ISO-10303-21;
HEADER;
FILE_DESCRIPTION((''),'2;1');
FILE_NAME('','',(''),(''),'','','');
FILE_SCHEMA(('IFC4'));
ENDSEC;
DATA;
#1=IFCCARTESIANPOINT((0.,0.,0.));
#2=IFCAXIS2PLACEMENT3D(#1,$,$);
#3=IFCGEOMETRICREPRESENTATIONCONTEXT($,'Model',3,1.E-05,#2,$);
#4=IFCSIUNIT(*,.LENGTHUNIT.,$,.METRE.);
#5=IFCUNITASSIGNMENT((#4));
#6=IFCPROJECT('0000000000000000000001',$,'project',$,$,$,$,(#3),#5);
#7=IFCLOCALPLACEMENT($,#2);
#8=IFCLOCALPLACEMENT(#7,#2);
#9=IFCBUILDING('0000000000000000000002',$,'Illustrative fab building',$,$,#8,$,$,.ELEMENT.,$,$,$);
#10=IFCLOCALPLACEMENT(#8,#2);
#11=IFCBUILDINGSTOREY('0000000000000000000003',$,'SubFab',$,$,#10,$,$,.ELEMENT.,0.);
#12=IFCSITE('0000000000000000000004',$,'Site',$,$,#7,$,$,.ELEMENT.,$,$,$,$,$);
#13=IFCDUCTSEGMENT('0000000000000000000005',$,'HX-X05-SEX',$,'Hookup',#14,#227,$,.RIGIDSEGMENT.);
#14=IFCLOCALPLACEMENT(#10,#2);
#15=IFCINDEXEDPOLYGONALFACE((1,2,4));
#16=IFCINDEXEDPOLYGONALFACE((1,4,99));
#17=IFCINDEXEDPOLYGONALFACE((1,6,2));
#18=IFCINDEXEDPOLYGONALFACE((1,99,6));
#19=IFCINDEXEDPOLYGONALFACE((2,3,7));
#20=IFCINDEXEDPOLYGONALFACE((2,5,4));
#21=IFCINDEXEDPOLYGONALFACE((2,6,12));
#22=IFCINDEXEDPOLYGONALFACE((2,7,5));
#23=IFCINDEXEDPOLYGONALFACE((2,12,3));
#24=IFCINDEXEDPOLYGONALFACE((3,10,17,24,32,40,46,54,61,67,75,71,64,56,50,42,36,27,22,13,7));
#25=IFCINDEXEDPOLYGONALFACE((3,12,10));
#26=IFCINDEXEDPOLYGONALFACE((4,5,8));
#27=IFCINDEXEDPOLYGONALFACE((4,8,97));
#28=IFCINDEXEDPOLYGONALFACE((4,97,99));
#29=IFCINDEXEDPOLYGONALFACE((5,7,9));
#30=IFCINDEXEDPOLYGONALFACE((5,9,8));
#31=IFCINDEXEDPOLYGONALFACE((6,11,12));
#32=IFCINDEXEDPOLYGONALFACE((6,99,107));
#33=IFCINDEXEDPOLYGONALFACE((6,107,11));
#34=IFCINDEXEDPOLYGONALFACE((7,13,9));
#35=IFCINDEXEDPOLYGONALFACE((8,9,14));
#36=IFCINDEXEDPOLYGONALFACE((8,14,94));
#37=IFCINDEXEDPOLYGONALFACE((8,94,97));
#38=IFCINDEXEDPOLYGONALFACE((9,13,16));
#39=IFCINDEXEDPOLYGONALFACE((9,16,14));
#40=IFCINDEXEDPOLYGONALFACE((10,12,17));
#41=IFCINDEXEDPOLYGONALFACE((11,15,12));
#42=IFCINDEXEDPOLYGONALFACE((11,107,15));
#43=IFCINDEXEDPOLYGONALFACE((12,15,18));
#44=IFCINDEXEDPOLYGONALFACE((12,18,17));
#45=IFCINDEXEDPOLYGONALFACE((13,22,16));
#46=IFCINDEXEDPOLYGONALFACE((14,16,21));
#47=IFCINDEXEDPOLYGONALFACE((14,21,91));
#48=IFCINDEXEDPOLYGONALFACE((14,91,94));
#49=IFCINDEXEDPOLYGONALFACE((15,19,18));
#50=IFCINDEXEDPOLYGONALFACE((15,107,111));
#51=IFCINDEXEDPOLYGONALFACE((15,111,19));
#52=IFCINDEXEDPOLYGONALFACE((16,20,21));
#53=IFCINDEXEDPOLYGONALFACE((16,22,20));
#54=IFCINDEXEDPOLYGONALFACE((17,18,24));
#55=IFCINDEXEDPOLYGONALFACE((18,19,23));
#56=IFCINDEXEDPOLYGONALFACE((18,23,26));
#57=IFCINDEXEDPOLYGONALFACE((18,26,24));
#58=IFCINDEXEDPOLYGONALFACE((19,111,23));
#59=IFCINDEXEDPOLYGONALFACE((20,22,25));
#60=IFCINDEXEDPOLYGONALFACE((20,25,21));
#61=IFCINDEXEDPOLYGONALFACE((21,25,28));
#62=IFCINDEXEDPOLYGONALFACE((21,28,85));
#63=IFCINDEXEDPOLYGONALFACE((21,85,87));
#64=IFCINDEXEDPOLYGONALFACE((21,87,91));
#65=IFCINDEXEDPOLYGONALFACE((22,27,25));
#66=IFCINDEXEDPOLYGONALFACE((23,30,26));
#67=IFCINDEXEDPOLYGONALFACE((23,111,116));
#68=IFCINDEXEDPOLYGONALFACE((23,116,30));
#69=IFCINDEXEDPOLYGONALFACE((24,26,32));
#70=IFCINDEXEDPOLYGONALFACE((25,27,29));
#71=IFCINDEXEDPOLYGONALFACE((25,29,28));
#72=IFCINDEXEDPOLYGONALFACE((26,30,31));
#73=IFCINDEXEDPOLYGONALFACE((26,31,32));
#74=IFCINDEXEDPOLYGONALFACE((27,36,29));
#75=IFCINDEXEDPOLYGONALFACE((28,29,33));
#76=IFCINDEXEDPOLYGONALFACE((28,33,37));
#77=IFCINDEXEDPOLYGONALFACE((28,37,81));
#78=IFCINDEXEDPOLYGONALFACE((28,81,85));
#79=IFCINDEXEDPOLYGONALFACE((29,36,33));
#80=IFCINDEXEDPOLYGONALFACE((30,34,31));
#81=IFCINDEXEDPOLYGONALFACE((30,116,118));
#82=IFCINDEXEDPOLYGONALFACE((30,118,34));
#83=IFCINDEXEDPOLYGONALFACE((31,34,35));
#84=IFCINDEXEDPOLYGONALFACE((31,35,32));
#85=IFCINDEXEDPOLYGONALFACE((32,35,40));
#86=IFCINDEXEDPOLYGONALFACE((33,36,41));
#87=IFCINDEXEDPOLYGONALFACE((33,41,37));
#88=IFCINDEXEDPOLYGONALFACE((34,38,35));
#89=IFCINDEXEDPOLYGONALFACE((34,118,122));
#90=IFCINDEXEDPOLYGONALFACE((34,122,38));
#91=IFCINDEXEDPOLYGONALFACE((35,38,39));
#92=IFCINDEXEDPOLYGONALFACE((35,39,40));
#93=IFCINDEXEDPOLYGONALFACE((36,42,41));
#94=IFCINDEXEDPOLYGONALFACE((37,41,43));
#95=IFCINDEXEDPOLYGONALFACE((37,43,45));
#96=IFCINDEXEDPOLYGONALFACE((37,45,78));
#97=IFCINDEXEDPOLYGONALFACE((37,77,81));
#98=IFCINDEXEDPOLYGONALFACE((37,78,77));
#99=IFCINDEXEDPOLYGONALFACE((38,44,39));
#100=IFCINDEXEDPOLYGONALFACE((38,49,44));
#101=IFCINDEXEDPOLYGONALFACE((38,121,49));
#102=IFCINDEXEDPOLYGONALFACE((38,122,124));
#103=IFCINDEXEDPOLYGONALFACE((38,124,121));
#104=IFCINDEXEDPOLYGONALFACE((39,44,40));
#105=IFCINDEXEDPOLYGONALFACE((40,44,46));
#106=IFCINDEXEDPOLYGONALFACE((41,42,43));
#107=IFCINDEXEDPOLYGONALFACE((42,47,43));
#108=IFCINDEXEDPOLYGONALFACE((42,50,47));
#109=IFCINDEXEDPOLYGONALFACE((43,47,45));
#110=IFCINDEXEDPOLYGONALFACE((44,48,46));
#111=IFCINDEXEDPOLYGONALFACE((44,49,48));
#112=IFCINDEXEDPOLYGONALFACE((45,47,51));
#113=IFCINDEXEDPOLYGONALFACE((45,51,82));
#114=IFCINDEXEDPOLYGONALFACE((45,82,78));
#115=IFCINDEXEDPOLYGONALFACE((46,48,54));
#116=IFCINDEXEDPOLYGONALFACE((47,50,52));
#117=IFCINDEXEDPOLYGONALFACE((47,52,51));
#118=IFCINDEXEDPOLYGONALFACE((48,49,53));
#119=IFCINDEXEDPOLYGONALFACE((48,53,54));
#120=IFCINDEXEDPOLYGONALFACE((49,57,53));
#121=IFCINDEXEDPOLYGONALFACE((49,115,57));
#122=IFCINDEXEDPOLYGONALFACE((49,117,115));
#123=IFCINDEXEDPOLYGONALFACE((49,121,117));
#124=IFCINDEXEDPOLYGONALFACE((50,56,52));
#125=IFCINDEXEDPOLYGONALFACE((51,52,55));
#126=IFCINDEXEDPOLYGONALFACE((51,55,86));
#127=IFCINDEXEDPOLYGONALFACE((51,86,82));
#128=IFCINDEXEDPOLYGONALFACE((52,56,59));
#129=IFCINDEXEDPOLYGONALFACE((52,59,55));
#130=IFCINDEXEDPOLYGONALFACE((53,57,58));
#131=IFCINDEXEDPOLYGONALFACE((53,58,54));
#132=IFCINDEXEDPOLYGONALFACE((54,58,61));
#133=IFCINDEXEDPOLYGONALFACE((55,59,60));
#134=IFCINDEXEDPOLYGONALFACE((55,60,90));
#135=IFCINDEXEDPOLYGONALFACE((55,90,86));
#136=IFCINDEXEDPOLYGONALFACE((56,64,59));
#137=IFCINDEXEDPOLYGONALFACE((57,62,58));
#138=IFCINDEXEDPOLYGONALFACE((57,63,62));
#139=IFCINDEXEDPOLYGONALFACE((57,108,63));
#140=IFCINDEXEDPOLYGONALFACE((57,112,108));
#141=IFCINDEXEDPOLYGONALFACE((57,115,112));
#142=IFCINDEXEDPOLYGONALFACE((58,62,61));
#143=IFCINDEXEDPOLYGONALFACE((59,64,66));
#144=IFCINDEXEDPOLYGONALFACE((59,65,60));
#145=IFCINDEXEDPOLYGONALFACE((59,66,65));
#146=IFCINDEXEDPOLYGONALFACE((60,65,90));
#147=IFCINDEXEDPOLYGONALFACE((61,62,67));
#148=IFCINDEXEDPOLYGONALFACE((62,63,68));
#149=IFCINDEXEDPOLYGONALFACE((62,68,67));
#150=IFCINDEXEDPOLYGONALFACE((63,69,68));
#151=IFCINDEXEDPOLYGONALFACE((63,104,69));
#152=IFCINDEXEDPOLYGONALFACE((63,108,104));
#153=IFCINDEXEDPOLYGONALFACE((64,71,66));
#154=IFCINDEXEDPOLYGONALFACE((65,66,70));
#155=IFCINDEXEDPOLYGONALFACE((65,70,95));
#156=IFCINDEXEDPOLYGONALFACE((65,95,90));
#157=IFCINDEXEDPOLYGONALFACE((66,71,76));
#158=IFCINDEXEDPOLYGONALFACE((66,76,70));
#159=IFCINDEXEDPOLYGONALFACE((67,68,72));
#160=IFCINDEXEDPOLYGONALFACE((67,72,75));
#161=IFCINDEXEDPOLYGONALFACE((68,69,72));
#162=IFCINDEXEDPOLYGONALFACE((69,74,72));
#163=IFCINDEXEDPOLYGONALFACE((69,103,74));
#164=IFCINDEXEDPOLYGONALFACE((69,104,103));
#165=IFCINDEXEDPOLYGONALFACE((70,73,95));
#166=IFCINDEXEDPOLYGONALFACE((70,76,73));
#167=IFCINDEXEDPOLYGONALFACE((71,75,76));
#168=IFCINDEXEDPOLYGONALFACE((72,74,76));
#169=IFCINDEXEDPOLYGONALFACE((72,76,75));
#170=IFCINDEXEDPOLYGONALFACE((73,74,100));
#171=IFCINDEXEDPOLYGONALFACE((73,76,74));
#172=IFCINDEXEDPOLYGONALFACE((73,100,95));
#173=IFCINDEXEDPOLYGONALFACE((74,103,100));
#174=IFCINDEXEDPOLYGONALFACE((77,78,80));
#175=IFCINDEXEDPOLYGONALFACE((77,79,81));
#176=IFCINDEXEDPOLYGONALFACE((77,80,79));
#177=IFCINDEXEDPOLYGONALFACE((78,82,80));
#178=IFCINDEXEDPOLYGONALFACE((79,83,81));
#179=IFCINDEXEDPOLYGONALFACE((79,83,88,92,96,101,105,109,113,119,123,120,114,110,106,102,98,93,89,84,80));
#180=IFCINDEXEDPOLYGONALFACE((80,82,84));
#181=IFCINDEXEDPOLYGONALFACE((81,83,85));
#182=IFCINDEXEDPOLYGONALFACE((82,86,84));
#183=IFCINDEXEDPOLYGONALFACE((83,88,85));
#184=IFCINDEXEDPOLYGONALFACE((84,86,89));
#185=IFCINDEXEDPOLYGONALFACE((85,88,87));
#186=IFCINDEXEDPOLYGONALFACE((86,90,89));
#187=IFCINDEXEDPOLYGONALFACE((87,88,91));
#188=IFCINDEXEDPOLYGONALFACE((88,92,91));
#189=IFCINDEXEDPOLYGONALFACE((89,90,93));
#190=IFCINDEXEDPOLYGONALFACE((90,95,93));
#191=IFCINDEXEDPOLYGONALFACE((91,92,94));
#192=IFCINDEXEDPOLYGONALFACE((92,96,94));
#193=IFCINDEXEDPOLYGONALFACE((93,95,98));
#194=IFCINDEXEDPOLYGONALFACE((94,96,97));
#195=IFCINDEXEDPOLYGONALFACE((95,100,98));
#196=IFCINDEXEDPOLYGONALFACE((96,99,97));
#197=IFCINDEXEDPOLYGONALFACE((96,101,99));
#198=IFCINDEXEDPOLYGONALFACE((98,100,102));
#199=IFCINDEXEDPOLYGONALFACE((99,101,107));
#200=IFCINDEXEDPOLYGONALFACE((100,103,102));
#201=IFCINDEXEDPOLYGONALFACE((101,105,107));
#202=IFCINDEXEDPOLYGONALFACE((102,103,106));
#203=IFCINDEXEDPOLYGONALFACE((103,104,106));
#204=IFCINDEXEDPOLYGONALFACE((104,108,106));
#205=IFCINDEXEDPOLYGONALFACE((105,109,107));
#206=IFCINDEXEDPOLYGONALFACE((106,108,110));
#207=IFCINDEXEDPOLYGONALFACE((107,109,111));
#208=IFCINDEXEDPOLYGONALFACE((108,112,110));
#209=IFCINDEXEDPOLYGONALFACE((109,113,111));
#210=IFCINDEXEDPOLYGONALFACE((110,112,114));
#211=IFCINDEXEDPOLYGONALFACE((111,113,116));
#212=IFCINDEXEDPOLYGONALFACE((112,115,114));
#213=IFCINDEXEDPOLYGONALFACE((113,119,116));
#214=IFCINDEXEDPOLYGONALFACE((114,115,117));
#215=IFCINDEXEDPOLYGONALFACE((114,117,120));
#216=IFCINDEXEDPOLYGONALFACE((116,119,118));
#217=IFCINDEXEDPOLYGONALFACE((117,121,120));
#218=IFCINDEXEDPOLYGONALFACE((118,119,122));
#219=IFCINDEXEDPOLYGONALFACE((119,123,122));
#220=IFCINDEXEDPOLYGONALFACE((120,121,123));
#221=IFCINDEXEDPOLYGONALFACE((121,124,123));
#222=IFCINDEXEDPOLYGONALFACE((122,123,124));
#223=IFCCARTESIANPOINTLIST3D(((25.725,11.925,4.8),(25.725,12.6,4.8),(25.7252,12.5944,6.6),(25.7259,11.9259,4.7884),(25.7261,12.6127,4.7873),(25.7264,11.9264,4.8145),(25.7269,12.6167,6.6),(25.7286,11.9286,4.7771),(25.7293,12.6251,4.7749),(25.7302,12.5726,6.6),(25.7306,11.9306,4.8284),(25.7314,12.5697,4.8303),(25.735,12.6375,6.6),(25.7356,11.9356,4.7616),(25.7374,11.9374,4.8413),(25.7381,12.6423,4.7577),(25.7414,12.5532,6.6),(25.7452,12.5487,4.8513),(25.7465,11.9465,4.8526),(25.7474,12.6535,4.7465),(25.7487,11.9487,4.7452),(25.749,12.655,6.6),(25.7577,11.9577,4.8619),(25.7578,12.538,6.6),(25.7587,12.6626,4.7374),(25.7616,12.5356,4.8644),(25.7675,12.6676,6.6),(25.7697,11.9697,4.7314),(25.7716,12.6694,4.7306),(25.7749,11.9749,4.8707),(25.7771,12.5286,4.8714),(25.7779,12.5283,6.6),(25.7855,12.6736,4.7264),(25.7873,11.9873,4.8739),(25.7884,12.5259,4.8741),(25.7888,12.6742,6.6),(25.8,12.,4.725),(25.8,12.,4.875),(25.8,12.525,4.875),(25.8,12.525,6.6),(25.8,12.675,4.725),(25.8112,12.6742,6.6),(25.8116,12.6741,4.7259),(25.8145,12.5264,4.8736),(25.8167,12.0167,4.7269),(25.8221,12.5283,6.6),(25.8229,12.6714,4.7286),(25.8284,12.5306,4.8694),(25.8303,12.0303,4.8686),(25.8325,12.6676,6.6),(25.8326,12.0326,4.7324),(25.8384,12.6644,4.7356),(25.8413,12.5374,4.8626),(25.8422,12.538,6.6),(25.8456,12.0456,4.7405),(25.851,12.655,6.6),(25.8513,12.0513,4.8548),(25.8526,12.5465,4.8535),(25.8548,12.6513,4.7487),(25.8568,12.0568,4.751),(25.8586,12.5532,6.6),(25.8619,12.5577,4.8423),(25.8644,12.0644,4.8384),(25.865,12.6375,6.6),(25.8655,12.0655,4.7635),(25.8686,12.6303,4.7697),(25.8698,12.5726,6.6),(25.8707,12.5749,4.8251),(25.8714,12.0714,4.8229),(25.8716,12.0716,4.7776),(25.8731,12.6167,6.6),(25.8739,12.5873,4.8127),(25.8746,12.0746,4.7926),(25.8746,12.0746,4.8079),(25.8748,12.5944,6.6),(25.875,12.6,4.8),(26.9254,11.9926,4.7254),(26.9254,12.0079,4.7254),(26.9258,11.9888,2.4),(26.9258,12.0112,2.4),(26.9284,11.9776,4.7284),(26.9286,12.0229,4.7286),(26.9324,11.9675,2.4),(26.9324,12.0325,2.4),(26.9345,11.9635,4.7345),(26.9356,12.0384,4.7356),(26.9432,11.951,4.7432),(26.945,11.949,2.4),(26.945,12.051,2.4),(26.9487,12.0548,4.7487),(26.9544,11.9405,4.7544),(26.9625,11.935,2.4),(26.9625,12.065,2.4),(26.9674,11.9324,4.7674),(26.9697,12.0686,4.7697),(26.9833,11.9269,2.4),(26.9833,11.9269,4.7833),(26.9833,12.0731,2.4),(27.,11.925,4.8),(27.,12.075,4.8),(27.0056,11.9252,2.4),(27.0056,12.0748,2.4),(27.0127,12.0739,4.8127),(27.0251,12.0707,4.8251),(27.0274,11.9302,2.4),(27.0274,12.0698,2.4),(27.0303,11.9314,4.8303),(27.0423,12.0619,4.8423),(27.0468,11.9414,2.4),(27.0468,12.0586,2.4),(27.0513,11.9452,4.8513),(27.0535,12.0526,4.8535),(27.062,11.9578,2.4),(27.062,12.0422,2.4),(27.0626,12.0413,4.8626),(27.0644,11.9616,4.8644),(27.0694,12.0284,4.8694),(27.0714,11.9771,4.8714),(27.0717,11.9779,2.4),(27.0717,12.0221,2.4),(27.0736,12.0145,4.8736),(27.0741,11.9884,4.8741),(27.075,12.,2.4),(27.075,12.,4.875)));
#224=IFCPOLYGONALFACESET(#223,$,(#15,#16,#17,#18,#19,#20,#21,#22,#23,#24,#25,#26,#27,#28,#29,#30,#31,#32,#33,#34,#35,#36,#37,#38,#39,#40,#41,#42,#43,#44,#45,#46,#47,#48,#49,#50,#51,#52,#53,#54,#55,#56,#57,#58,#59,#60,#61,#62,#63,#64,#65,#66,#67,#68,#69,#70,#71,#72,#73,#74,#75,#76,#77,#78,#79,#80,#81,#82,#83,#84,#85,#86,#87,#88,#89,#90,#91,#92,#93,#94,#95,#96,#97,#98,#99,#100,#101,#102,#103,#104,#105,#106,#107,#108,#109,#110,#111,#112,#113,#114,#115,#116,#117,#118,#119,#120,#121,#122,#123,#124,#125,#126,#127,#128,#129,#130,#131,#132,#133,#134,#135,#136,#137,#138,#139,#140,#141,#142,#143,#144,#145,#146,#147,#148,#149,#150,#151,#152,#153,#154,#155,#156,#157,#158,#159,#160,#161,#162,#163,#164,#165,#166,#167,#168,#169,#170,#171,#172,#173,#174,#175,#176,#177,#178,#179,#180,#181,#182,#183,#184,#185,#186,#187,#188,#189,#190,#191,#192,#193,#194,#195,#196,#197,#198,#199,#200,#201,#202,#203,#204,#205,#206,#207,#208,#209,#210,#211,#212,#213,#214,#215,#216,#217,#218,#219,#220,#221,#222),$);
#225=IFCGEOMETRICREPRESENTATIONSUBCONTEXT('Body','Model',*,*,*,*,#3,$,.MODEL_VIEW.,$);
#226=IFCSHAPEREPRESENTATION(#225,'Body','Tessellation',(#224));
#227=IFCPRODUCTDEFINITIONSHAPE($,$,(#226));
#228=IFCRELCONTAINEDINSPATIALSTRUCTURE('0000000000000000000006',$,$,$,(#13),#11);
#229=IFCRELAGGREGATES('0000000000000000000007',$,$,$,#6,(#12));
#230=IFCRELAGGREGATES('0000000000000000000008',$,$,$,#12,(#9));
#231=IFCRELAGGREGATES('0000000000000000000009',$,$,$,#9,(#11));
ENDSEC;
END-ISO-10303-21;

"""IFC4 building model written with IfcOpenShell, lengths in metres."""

from ifc_helpers import new_model, entity, si_unit, origin, place, context, subcontext, project, spatial, element, save


model = new_model("IFC4")

# Units and contexts
model_context = context("Model", 3, precision=1e-05, world=origin())
body_context = subcontext(model_context, "Body", "Model", "MODEL_VIEW")
ifc_project = project(units=[si_unit("LENGTHUNIT", "METRE")], contexts=[model_context])

# Site, building, storey
site_placement = place(None, origin())
site = spatial("IfcSite", under=ifc_project, at=site_placement, Name="Site", CompositionType="ELEMENT")
building_placement = place(site_placement, origin())
building = spatial("IfcBuilding", under=site, at=building_placement, Name="Illustrative fab building", CompositionType="ELEMENT")
storey_placement = place(building_placement, origin())
storey = spatial("IfcBuildingStorey", under=building, at=storey_placement, Name="SubFab", CompositionType="ELEMENT", Elevation=0.0)

# Duct segment
duct_segment_1_placement = place(storey_placement, origin())
element("IfcDuctSegment", 1, at=duct_segment_1_placement, inside=storey, Name="HX-X05-SEX", ObjectType="Hookup", PredefinedType="RIGIDSEGMENT", context=body_context, shape_type="AdvancedSweptSolid", body=[
    entity("IfcSweptDiskSolid", entity("IfcPolyline", [entity("IfcCartesianPoint", [27.0, 12.0, 2.4]), entity("IfcCartesianPoint", [27.0, 12.0, 4.8]), entity("IfcCartesianPoint", [25.8, 12.0, 4.8]), entity("IfcCartesianPoint", [25.8, 12.6, 4.8]), entity("IfcCartesianPoint", [25.8, 12.6, 6.6])]), 0.075),
])

save(model, "model.ifc")
